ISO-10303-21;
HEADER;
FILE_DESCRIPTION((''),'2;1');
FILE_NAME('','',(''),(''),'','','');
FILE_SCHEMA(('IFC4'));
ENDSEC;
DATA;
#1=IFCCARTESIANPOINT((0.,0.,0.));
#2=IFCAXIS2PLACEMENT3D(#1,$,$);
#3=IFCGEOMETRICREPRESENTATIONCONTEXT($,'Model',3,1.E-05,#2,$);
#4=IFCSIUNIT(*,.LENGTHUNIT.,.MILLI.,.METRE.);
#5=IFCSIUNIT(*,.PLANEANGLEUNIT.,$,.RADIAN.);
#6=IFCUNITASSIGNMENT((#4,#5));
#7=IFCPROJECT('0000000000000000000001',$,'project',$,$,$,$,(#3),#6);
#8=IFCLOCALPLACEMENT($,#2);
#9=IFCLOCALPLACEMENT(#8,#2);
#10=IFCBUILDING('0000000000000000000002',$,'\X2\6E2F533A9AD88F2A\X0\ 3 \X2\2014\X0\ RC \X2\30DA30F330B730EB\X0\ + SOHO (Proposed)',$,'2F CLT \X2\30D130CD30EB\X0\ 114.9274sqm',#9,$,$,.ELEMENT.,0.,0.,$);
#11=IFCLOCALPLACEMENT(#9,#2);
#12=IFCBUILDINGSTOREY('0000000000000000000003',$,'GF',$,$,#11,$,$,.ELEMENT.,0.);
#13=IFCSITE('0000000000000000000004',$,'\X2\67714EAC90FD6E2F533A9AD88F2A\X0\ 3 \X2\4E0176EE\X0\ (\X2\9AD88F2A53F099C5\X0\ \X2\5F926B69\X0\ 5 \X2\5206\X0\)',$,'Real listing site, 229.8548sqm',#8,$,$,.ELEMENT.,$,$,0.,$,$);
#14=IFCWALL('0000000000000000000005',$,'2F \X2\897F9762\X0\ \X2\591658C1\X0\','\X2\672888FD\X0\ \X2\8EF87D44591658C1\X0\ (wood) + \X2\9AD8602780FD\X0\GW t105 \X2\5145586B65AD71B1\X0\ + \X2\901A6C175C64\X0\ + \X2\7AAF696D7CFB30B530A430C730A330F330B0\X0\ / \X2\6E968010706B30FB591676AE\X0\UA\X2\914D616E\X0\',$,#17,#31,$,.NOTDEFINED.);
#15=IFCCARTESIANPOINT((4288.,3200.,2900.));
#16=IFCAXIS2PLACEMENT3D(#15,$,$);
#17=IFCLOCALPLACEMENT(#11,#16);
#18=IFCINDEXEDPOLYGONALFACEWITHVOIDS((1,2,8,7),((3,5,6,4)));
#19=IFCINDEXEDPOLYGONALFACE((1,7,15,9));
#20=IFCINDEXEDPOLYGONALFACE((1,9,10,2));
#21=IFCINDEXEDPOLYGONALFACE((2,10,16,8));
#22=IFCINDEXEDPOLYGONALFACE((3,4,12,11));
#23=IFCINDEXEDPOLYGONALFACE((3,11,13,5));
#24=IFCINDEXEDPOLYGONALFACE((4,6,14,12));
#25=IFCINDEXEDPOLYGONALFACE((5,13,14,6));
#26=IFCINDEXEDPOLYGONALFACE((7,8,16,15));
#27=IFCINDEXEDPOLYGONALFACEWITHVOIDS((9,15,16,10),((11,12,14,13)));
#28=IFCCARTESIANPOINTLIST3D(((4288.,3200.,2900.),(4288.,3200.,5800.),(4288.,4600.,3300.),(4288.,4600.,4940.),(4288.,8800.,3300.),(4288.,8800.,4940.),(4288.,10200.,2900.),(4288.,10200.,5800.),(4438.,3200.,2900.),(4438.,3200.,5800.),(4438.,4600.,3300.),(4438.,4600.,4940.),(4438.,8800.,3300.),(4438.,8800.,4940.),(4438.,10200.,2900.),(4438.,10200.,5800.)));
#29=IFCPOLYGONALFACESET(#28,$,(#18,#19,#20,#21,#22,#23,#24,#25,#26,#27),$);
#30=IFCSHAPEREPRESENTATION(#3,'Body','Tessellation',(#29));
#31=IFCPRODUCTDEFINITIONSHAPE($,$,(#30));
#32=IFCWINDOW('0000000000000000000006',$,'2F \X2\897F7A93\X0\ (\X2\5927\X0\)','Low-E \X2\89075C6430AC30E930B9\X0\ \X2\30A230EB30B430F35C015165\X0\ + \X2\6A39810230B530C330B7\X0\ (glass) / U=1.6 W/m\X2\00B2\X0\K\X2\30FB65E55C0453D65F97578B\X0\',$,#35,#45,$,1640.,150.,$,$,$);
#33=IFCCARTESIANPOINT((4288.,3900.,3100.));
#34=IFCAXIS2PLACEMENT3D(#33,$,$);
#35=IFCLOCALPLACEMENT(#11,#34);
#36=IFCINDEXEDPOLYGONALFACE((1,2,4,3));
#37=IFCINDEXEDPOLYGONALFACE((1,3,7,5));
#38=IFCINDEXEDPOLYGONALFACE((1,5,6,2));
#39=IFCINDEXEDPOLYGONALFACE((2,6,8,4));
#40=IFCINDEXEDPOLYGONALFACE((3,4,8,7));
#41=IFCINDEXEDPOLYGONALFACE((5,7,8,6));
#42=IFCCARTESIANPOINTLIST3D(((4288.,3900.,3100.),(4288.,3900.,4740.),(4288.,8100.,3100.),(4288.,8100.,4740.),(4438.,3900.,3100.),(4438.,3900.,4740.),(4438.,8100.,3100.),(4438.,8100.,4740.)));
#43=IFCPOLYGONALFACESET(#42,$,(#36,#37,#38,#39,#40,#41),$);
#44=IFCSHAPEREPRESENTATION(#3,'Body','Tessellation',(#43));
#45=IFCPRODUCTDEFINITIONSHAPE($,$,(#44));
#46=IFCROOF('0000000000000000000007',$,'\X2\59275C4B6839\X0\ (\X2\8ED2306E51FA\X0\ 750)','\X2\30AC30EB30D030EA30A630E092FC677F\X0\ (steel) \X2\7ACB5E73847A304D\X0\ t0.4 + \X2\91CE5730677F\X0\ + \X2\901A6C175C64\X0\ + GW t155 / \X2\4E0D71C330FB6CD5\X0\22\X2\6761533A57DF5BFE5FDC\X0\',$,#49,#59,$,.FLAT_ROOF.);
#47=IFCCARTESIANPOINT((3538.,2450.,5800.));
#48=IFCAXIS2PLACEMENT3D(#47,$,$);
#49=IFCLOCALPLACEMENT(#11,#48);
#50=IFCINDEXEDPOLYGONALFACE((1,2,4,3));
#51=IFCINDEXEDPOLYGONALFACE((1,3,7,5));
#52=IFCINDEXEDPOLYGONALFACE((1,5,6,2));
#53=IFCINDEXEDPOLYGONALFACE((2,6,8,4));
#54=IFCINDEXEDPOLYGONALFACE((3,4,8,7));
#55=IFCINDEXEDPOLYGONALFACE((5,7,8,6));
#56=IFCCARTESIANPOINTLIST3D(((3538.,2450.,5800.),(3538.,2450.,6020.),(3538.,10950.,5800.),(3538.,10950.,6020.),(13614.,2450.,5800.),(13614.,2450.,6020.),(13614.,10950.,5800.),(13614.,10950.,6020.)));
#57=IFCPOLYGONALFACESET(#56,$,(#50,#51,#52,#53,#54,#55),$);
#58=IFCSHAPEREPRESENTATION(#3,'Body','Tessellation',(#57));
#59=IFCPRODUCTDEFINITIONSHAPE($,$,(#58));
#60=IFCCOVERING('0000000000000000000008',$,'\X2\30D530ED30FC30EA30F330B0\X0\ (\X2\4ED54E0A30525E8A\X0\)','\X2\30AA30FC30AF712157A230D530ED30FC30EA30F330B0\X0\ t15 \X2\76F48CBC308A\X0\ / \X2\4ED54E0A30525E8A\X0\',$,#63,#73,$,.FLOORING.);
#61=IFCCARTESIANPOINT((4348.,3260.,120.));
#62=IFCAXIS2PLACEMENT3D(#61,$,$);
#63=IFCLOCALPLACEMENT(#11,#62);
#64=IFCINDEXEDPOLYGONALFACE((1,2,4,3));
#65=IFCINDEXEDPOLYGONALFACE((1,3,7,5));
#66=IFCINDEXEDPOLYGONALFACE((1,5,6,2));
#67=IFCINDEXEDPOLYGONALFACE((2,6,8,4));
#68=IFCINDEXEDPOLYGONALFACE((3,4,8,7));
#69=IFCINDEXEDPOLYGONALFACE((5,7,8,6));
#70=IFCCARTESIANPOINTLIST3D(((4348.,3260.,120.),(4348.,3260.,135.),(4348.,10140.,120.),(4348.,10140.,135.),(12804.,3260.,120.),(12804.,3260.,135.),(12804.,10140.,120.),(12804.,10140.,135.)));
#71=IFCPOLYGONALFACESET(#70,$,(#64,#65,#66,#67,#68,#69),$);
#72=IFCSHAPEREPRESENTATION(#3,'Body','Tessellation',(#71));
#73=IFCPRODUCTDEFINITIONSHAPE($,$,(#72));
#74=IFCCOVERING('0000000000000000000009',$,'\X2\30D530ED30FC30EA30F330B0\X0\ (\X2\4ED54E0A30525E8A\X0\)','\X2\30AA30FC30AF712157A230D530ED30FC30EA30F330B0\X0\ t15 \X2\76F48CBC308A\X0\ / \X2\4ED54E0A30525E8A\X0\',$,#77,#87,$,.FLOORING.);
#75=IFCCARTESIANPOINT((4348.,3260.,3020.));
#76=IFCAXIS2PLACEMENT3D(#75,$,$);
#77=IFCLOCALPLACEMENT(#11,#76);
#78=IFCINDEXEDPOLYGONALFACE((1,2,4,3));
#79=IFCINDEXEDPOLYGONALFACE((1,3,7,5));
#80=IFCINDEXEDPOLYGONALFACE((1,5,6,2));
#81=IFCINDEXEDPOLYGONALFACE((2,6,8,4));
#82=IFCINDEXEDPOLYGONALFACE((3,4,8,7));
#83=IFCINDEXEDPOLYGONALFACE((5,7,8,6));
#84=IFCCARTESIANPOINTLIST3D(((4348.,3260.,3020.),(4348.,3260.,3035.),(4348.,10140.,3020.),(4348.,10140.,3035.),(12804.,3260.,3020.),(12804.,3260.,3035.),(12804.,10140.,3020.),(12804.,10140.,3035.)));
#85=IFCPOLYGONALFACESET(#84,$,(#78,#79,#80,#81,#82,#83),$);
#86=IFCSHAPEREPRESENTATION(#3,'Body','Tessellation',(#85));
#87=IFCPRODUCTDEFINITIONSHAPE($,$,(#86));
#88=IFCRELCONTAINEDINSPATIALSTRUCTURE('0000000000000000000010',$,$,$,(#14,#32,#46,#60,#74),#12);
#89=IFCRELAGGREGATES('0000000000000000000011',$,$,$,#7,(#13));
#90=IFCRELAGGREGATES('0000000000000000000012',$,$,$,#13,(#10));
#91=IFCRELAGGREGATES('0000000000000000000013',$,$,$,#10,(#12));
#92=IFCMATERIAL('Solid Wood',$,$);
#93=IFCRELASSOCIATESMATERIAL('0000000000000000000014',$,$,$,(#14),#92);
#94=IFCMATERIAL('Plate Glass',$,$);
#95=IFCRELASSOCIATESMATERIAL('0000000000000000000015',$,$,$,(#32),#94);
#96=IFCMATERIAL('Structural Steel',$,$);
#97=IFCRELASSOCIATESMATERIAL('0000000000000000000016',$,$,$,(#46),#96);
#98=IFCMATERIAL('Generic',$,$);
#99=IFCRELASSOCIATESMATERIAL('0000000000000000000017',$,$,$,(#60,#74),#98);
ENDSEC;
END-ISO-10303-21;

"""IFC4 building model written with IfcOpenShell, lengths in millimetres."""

from ifc_helpers import new_model, si_unit, frame, frame_2d, origin, place, context, project, spatial, rectangle, extrude, material, element, fill, save


model = new_model("IFC4")

# Units and contexts
model_context = context("Model", 3, precision=1e-05, world=origin())
ifc_project = project(units=[si_unit("LENGTHUNIT", "METRE", prefix="MILLI"), si_unit("PLANEANGLEUNIT", "RADIAN")], contexts=[model_context])

# Site, building, storey
site_placement = place(None, origin())
site = spatial("IfcSite", under=ifc_project, at=site_placement, Name="東京都港区高輪 3 丁目 (高輪台駅 徒歩 5 分)", ObjectType="Real listing site, 229.8548sqm", CompositionType="ELEMENT", RefElevation=0.0)
building_placement = place(site_placement, origin())
building = spatial("IfcBuilding", under=site, at=building_placement, Name="港区高輪 3 — RC ペンシル + SOHO (Proposed)", ObjectType="2F CLT パネル 114.9274sqm", CompositionType="ELEMENT", ElevationOfRefHeight=0.0, ElevationOfTerrain=0.0)
storey_placement = place(building_placement, origin())
storey = spatial("IfcBuildingStorey", under=building, at=storey_placement, Name="GF", CompositionType="ELEMENT", Elevation=0.0)

# Shared definitions
ifc_material_1 = material(Name="Solid Wood")

# Shared definitions
ifc_material_2 = material(Name="Plate Glass")

# Wall, opening, window
wall_1_placement = place(storey_placement, frame((4288.0, 3200.0, 2900.0)))
wall_1 = element("IfcWall", 1, at=wall_1_placement, inside=storey, material=ifc_material_1, Name="2F 西面 外壁", Description="木製 軸組外壁 (wood) + 高性能GW t105 充填断熱 + 通気層 + 窯業系サイディング / 準耐火・外皮UA配慮", PredefinedType="NOTDEFINED", context=model_context, shape_type="SweptSolid", body=[
    extrude(rectangle(XDim=150.0, YDim=7000.0, at=frame_2d((75.0, 3500.0))), frame((4288.0, 3200.0, 2900.0)), (0.0, 0.0, 1.0), 2900.0),
])
opening_1_placement = place(storey_placement, frame((4288.0, 3900.0, 3100.0)))
opening_1 = element("IfcOpeningElement", 2, at=opening_1_placement, cuts=wall_1, PredefinedType="NOTDEFINED", context=model_context, shape_type="SweptSolid", body=[
    extrude(rectangle(XDim=150.0, YDim=4200.0, at=frame_2d((75.0, 2100.0))), frame((4288.0, 3900.0, 3100.0)), (0.0, 0.0, 1.0), 1640.0),
])
window_1_placement = place(storey_placement, frame((4288.0, 3900.0, 3100.0)))
window_1 = element("IfcWindow", 3, at=window_1_placement, inside=storey, material=ifc_material_2, Name="2F 西窓 (大)", Description="Low-E 複層ガラス アルゴン封入 + 樹脂サッシ (glass) / U=1.6 W/m²K・日射取得型", OverallHeight=1640.0, OverallWidth=150.0, context=model_context, shape_type="SweptSolid", body=[
    extrude(rectangle(XDim=150.0, YDim=4200.0, at=frame_2d((75.0, 2100.0))), frame((4288.0, 3900.0, 3100.0)), (0.0, 0.0, 1.0), 1640.0),
])
fill(opening_1, window_1)

# Roof
ifc_material_3 = material(Name="Structural Steel")
roof_placement = place(storey_placement, frame((3538.0, 2450.0, 5800.0)))
element("IfcRoof", 4, at=roof_placement, inside=storey, material=ifc_material_3, Name="大屋根 (軒の出 750)", Description="ガルバリウム鋼板 (steel) 立平葺き t0.4 + 野地板 + 通気層 + GW t155 / 不燃・法22条区域対応", PredefinedType="FLAT_ROOF", context=model_context, shape_type="SweptSolid", body=[
    extrude(rectangle(XDim=10076.0, YDim=8500.0, at=frame_2d((5038.0, 4250.0))), frame((3538.0, 2450.0, 5800.0)), (0.0, 0.0, 1.0), 220.0),
])

# Coverings
ifc_material_4 = material(Name="Generic")
covering_1_placement = place(storey_placement, frame((4348.0, 3260.0, 120.0)))
element("IfcCovering", 5, at=covering_1_placement, inside=storey, material=ifc_material_4, Name="フローリング (仕上げ床)", Description="オーク無垢フローリング t15 直貼り / 仕上げ床", PredefinedType="FLOORING", context=model_context, shape_type="SweptSolid", body=[
    extrude(rectangle(XDim=8456.0, YDim=6880.0, at=frame_2d((4228.0, 3440.0))), frame((4348.0, 3260.0, 120.0)), (0.0, 0.0, 1.0), 15.0),
])
covering_2_placement = place(storey_placement, frame((4348.0, 3260.0, 3020.0)))
element("IfcCovering", 6, at=covering_2_placement, inside=storey, material=ifc_material_4, Name="フローリング (仕上げ床)", Description="オーク無垢フローリング t15 直貼り / 仕上げ床", PredefinedType="FLOORING", context=model_context, shape_type="SweptSolid", body=[
    extrude(rectangle(XDim=8456.0, YDim=6880.0, at=frame_2d((4228.0, 3440.0))), frame((4348.0, 3260.0, 3020.0)), (0.0, 0.0, 1.0), 15.0),
])

save(model, "model.ifc")
